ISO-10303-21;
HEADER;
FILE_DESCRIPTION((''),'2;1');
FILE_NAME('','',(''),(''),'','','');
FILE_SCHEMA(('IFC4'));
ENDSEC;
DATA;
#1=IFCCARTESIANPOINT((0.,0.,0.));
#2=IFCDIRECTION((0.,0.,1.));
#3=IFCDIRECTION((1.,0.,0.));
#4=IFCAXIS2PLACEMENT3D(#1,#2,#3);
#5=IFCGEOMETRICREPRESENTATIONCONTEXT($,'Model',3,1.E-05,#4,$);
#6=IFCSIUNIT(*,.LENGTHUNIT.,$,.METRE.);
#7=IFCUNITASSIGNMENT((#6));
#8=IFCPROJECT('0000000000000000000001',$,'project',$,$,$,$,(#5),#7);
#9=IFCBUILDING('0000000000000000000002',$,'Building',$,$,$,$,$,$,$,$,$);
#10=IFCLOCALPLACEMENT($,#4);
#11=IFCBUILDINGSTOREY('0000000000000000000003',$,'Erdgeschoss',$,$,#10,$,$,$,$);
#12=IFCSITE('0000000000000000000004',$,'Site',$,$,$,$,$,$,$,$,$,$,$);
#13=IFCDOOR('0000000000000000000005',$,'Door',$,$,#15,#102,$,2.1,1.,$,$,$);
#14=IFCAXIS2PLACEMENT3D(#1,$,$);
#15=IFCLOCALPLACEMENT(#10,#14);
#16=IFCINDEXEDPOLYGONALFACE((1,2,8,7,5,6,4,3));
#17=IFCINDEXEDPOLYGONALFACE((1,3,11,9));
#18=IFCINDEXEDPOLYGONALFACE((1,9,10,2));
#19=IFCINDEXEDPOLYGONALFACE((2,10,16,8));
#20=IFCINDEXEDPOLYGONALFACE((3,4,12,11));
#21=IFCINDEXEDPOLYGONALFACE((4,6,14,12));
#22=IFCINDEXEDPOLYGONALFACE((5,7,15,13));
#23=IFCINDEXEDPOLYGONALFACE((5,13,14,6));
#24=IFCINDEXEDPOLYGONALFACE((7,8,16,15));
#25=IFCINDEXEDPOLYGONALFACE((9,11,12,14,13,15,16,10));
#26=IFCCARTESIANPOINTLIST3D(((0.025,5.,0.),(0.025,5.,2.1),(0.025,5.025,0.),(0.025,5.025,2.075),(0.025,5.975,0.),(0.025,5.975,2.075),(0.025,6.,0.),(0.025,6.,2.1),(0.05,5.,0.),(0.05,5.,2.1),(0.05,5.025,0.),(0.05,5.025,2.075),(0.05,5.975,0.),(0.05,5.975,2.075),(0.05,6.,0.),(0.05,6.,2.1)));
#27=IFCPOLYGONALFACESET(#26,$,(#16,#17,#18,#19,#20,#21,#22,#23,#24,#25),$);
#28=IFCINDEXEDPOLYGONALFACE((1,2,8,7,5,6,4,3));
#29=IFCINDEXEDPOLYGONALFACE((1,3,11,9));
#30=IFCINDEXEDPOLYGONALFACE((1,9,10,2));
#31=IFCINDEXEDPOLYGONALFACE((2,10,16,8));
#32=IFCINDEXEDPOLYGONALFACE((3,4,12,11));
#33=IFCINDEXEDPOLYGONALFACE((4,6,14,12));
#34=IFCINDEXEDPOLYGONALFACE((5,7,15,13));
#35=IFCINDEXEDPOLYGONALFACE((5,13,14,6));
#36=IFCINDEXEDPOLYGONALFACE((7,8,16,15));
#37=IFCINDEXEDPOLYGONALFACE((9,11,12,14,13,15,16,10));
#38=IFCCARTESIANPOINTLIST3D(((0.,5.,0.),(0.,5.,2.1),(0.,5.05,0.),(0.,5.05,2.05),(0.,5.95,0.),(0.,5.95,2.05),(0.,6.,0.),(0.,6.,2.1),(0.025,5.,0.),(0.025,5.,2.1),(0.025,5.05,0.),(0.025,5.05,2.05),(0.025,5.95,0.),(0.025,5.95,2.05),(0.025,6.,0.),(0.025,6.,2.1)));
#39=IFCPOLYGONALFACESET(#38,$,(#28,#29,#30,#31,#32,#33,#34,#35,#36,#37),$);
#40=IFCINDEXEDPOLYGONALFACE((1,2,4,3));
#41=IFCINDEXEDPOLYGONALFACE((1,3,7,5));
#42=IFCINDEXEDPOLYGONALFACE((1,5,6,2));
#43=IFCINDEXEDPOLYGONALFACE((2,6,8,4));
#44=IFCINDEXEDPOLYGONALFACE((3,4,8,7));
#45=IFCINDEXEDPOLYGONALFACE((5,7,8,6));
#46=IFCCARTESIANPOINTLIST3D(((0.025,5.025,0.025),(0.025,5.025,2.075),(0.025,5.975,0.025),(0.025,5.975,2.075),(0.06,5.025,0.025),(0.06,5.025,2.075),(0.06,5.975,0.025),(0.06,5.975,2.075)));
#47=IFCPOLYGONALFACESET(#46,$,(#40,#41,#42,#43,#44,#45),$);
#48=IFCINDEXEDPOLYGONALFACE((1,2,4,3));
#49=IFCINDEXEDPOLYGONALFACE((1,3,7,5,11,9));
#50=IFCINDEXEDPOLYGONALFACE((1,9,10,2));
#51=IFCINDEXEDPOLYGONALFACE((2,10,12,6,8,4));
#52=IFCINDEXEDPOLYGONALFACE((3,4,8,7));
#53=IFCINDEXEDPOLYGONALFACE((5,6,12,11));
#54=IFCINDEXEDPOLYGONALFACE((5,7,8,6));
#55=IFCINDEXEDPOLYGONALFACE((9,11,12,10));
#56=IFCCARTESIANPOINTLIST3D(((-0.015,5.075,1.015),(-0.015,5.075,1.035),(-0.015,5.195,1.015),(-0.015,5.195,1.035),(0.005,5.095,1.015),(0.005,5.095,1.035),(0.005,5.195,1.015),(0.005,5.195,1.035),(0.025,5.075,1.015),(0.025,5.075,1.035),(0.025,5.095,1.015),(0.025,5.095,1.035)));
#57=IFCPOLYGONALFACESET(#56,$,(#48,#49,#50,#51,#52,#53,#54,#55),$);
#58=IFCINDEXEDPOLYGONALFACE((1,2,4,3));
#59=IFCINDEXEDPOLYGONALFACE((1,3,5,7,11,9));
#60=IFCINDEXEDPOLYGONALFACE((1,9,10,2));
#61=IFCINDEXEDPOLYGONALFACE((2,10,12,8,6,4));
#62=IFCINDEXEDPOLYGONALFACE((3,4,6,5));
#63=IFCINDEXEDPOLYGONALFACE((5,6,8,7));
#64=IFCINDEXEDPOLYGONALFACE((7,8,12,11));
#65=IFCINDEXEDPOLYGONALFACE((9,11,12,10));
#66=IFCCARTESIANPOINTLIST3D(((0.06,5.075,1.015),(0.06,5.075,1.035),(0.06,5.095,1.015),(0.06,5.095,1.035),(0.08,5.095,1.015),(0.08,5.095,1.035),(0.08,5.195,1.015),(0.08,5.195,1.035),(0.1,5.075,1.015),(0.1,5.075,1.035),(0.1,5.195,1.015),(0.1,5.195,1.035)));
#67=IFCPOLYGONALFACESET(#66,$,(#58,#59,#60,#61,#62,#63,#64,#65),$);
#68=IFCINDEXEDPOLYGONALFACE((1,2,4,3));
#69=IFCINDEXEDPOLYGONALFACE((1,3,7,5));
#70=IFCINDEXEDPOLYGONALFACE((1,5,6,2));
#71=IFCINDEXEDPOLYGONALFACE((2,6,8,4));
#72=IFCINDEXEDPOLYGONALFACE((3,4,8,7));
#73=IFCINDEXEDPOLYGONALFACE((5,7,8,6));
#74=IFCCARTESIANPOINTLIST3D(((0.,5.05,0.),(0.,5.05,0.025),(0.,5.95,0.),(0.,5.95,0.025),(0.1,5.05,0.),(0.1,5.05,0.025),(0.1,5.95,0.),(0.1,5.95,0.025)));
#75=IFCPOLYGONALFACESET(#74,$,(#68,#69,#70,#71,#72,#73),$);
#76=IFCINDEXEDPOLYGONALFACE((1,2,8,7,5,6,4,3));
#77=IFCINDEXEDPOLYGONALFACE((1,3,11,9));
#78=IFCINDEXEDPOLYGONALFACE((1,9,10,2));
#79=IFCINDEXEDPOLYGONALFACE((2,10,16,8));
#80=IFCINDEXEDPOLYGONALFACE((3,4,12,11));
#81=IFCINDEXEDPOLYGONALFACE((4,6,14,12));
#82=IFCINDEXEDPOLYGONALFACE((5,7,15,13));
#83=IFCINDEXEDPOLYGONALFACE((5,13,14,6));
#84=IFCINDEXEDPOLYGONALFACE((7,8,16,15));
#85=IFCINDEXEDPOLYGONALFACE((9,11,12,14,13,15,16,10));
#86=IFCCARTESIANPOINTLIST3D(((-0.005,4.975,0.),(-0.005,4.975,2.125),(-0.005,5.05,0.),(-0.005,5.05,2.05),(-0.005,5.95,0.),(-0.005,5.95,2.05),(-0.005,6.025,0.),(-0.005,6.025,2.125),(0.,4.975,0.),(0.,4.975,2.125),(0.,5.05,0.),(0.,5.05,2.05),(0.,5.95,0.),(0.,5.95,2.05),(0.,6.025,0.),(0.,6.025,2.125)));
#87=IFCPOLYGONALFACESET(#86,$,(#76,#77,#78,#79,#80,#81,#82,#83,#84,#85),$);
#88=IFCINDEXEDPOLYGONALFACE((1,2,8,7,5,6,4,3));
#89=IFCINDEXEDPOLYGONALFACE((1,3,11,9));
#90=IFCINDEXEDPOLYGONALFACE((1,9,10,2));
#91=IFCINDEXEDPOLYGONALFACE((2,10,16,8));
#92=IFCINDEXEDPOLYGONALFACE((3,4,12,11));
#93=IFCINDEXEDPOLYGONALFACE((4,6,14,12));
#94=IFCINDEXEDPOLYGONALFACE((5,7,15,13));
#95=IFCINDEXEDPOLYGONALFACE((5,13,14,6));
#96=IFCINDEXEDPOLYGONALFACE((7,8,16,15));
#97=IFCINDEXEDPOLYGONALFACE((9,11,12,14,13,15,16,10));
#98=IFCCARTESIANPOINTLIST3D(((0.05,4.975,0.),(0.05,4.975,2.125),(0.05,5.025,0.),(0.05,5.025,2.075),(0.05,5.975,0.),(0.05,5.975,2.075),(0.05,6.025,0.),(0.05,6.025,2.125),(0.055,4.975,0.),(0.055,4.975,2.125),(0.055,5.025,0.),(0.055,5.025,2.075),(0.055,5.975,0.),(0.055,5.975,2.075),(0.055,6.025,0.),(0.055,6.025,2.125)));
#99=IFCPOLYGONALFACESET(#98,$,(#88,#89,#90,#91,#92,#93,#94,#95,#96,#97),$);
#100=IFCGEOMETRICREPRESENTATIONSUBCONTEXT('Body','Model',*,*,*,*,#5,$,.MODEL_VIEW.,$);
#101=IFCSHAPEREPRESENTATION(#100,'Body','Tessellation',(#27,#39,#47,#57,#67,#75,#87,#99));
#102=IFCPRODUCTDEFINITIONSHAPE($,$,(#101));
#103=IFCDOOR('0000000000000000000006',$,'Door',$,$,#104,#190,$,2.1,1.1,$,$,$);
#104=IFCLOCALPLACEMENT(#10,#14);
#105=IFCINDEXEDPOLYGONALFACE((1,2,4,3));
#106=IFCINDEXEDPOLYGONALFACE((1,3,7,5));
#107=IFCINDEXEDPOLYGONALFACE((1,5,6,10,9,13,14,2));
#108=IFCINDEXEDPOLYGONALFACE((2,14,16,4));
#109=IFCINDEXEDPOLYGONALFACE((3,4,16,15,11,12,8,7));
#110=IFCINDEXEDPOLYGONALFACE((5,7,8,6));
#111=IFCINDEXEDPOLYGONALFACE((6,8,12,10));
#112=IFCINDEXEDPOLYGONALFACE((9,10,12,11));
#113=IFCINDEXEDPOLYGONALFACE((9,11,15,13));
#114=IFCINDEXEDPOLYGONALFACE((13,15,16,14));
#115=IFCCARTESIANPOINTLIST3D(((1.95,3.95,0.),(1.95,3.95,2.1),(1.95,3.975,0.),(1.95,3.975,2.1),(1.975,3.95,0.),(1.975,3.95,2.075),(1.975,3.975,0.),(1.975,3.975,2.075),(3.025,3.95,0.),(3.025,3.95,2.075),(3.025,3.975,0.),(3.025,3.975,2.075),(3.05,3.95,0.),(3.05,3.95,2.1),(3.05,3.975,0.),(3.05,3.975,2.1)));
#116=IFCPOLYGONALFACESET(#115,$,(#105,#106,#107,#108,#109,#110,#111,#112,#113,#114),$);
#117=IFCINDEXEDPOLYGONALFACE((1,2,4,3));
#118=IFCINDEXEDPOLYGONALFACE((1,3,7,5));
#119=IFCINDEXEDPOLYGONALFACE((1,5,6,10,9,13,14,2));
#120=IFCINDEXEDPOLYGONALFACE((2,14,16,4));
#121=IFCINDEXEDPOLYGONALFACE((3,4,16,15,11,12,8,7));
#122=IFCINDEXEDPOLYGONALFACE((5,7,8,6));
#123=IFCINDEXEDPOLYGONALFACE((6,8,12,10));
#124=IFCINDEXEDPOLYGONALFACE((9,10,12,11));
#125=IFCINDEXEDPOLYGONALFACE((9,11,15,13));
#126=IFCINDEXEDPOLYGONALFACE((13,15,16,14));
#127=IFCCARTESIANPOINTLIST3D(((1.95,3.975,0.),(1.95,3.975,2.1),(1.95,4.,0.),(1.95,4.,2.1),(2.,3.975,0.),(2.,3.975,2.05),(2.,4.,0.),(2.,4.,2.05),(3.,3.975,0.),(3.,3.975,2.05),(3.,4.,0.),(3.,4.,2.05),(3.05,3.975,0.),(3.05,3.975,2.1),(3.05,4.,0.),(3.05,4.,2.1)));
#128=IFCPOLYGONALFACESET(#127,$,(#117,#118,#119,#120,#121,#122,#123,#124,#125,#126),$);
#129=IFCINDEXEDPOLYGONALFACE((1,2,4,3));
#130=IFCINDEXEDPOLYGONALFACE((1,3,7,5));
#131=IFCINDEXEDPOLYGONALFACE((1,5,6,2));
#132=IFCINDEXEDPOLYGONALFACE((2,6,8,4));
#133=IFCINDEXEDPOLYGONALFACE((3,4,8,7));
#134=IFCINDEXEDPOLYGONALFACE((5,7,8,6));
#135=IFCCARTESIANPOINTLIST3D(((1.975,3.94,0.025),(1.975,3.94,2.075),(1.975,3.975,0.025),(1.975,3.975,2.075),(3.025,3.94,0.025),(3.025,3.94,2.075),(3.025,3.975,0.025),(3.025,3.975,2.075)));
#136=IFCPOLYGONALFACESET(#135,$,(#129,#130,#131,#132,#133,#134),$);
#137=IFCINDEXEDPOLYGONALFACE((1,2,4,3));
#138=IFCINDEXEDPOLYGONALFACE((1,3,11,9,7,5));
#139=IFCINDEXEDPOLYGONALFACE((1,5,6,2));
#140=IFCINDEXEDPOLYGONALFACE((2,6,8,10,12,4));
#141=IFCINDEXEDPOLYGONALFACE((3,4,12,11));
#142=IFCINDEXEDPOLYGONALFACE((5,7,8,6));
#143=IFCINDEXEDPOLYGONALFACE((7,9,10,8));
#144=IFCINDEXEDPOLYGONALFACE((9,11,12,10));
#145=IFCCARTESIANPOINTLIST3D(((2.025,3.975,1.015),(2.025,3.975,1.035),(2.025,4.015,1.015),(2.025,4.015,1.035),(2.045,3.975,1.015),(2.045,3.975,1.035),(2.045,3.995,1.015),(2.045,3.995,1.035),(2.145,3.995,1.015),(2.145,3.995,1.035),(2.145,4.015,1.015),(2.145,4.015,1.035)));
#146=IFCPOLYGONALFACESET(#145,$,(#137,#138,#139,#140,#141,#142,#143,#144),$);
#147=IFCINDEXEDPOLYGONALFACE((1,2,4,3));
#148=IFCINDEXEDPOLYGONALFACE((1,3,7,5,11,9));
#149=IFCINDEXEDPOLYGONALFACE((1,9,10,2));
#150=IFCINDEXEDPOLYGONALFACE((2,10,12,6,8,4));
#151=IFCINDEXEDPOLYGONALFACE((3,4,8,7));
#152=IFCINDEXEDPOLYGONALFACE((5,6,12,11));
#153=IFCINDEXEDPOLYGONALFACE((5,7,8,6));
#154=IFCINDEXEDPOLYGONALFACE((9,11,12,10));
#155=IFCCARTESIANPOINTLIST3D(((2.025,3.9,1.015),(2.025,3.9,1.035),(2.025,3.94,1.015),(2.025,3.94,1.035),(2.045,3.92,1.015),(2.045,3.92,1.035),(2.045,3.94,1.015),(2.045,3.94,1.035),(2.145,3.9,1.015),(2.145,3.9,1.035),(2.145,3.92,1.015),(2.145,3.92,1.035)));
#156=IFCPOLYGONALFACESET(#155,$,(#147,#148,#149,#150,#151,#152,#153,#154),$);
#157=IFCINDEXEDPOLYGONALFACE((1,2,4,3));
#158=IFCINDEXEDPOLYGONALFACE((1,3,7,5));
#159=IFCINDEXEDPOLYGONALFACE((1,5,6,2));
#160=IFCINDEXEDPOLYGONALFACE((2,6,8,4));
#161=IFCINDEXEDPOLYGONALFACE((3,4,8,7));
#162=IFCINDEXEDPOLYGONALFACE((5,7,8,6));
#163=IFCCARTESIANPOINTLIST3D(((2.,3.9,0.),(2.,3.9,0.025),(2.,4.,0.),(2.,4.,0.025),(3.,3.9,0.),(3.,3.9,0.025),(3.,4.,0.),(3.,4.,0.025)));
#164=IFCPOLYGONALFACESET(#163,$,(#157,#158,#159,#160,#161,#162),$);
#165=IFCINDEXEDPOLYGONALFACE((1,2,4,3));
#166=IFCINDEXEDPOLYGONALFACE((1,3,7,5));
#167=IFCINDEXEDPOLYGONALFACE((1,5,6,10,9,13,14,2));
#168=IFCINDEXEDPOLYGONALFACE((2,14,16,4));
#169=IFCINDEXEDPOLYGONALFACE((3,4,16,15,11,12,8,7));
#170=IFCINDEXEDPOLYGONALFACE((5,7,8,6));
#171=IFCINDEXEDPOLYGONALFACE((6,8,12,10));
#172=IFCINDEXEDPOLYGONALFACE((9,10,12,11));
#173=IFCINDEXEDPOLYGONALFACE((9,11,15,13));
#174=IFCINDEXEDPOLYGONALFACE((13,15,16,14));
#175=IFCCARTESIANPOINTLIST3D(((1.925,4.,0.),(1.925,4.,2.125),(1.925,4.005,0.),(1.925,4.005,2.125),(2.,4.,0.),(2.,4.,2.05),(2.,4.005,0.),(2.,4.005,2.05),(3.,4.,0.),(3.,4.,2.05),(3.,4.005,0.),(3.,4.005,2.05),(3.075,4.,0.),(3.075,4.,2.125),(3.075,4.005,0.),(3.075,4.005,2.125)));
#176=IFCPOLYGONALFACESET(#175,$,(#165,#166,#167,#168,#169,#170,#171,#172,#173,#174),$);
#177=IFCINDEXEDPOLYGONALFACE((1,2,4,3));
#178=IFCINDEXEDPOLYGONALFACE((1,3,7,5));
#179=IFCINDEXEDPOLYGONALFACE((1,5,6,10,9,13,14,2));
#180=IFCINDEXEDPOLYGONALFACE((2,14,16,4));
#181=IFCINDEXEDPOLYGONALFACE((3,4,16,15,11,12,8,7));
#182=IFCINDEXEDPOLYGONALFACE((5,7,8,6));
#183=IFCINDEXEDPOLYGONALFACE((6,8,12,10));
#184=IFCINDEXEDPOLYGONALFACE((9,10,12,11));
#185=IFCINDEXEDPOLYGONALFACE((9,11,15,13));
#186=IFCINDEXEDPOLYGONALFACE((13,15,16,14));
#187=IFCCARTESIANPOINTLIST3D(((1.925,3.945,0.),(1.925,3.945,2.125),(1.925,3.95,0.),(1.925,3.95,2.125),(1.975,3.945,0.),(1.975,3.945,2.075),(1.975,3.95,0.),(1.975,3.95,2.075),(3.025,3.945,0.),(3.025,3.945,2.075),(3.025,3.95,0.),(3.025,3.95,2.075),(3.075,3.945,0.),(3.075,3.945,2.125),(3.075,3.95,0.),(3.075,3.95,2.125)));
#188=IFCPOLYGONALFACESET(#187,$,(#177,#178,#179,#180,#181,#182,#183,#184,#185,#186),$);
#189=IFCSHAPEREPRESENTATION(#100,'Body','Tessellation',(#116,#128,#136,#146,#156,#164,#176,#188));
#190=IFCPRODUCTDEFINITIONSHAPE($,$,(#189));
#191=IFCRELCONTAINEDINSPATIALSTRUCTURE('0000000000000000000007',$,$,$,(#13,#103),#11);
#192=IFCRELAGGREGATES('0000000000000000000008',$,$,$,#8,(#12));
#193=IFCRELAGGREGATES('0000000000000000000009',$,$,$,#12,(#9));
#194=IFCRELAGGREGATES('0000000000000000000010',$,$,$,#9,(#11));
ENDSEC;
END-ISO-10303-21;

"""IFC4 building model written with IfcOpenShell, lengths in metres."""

from ifc_helpers import new_model, si_unit, frame, origin_with_axes, place, context, subcontext, project, spatial, line, indexed_curve, outline, extrude, element, save


model = new_model("IFC4")

# Units and contexts
model_context = context("Model", 3, precision=1e-05, world=origin_with_axes())
body_context = subcontext(model_context, "Body", "Model", "MODEL_VIEW")
ifc_project = project(units=[si_unit("LENGTHUNIT", "METRE")], contexts=[model_context])

# Site, building, storey
site = spatial("IfcSite", under=ifc_project, Name="Site")
building = spatial("IfcBuilding", under=site, Name="Building")
storey_placement = place(None, origin_with_axes())
storey = spatial("IfcBuildingStorey", under=building, at=storey_placement, Name="Erdgeschoss")

# Doors
door_1_placement = place(storey_placement, frame((0.0, 6.0, 0.0), z_axis=(0.0, 0.0, 1.0), x_axis=(0.0, -1.0, 0.0)))
element("IfcDoor", 1, at=door_1_placement, inside=storey, Name="Door", OverallHeight=2.1, OverallWidth=1.0, context=body_context, shape_type="SweptSolid", body=[
    extrude(outline(indexed_curve([(0.0, 0.0), (0.0, 2.1), (1.0, 2.1), (1.0, 0.0), (0.975, 0.0), (0.975, 2.075), (0.025, 2.075), (0.025, 0.0)], segments=[line(1, 2, 3, 4, 5, 6, 7, 8, 1)])), frame((0.0, 0.025, 0.0), z_axis=(0.0, -1.0, 0.0), x_axis=(1.0, 0.0, 0.0)), (0.0, 0.0, -1.0), 0.025),
    extrude(outline(indexed_curve([(0.0, 0.0), (0.0, 2.1), (1.0, 2.1), (1.0, 0.0), (0.95, 0.0), (0.95, 2.05), (0.05, 2.05), (0.05, 0.0)], segments=[line(1, 2, 3, 4, 5, 6, 7, 8, 1)])), frame((0.0, 0.0, 0.0), z_axis=(0.0, -1.0, 0.0), x_axis=(1.0, 0.0, 0.0)), (0.0, 0.0, -1.0), 0.025),
    extrude(outline(indexed_curve([(0.0, 0.0), (0.95, 0.0), (0.95, 0.035), (0.0, 0.035)], segments=[line(1, 2, 3, 4, 1)])), frame((0.025, 0.025, 0.025), z_axis=(0.0, 0.0, 1.0), x_axis=(1.0, 0.0, 0.0)), (0.0, 0.0, 1.0), 2.05),
    extrude(outline(indexed_curve([(0.0, 0.0), (0.0, -0.04), (-0.12, -0.04), (-0.12, -0.02), (-0.02, -0.02), (-0.02, 0.0)], segments=[line(1, 2, 3, 4, 5, 6, 1)])), frame((0.925, 0.025, 1.015), z_axis=(0.0, 0.0, 1.0), x_axis=(1.0, 0.0, 0.0)), (0.0, 0.0, 1.0), 0.02),
    extrude(outline(indexed_curve([(0.0, 0.0), (0.0, 0.04), (-0.12, 0.04), (-0.12, 0.02), (-0.02, 0.02), (-0.02, 0.0)], segments=[line(1, 2, 3, 4, 5, 6, 1)])), frame((0.925, 0.06, 1.015), z_axis=(0.0, 0.0, 1.0), x_axis=(1.0, 0.0, 0.0)), (0.0, 0.0, 1.0), 0.02),
    extrude(outline(indexed_curve([(0.0, 0.0), (0.9, 0.0), (0.9, 0.1), (0.0, 0.1)], segments=[line(1, 2, 3, 4, 1)])), frame((0.05, 0.0, 0.0), z_axis=(0.0, 0.0, 1.0), x_axis=(1.0, 0.0, 0.0)), (0.0, 0.0, 1.0), 0.025),
    extrude(outline(indexed_curve([(0.0, 0.0), (0.0, 2.125), (1.05, 2.125), (1.05, 0.0), (0.975, 0.0), (0.975, 2.05), (0.075, 2.05), (0.075, 0.0)], segments=[line(1, 2, 3, 4, 5, 6, 7, 8, 1)])), frame((-0.025, -0.005, 0.0), z_axis=(0.0, -1.0, 0.0), x_axis=(1.0, 0.0, 0.0)), (0.0, 0.0, -1.0), 0.005),
    extrude(outline(indexed_curve([(0.0, 0.0), (0.0, 2.125), (1.05, 2.125), (1.05, 0.0), (1.0, 0.0), (1.0, 2.075), (0.05, 2.075), (0.05, 0.0)], segments=[line(1, 2, 3, 4, 5, 6, 7, 8, 1)])), frame((-0.025, 0.05, 0.0), z_axis=(0.0, -1.0, 0.0), x_axis=(1.0, 0.0, 0.0)), (0.0, 0.0, -1.0), 0.005),
])
door_2_placement = place(storey_placement, frame((3.05, 4.0, 0.0), z_axis=(0.0, 0.0, 1.0), x_axis=(-1.0, 0.0, 0.0)))
element("IfcDoor", 2, at=door_2_placement, inside=storey, Name="Door", OverallHeight=2.1, OverallWidth=1.1, context=body_context, shape_type="SweptSolid", body=[
    extrude(outline(indexed_curve([(0.0, 0.0), (0.0, 2.1), (1.1, 2.1), (1.1, 0.0), (1.075, 0.0), (1.075, 2.075), (0.025, 2.075), (0.025, 0.0)], segments=[line(1, 2, 3, 4, 5, 6, 7, 8, 1)])), frame((0.0, 0.025, 0.0), z_axis=(0.0, -1.0, 0.0), x_axis=(1.0, 0.0, 0.0)), (0.0, 0.0, -1.0), 0.025),
    extrude(outline(indexed_curve([(0.0, 0.0), (0.0, 2.1), (1.1, 2.1), (1.1, 0.0), (1.05, 0.0), (1.05, 2.05), (0.05, 2.05), (0.05, 0.0)], segments=[line(1, 2, 3, 4, 5, 6, 7, 8, 1)])), frame((0.0, 0.0, 0.0), z_axis=(0.0, -1.0, 0.0), x_axis=(1.0, 0.0, 0.0)), (0.0, 0.0, -1.0), 0.025),
    extrude(outline(indexed_curve([(0.0, 0.0), (1.05, 0.0), (1.05, 0.035), (0.0, 0.035)], segments=[line(1, 2, 3, 4, 1)])), frame((0.025, 0.025, 0.025), z_axis=(0.0, 0.0, 1.0), x_axis=(1.0, 0.0, 0.0)), (0.0, 0.0, 1.0), 2.05),
    extrude(outline(indexed_curve([(0.0, 0.0), (0.0, -0.04), (-0.12, -0.04), (-0.12, -0.02), (-0.02, -0.02), (-0.02, 0.0)], segments=[line(1, 2, 3, 4, 5, 6, 1)])), frame((1.025, 0.025, 1.015), z_axis=(0.0, 0.0, 1.0), x_axis=(1.0, 0.0, 0.0)), (0.0, 0.0, 1.0), 0.02),
    extrude(outline(indexed_curve([(0.0, 0.0), (0.0, 0.04), (-0.12, 0.04), (-0.12, 0.02), (-0.02, 0.02), (-0.02, 0.0)], segments=[line(1, 2, 3, 4, 5, 6, 1)])), frame((1.025, 0.06, 1.015), z_axis=(0.0, 0.0, 1.0), x_axis=(1.0, 0.0, 0.0)), (0.0, 0.0, 1.0), 0.02),
    extrude(outline(indexed_curve([(0.0, 0.0), (1.0, 0.0), (1.0, 0.1), (0.0, 0.1)], segments=[line(1, 2, 3, 4, 1)])), frame((0.05, 0.0, 0.0), z_axis=(0.0, 0.0, 1.0), x_axis=(1.0, 0.0, 0.0)), (0.0, 0.0, 1.0), 0.025),
    extrude(outline(indexed_curve([(0.0, 0.0), (0.0, 2.125), (1.15, 2.125), (1.15, 0.0), (1.075, 0.0), (1.075, 2.05), (0.075, 2.05), (0.075, 0.0)], segments=[line(1, 2, 3, 4, 5, 6, 7, 8, 1)])), frame((-0.025, -0.005, 0.0), z_axis=(0.0, -1.0, 0.0), x_axis=(1.0, 0.0, 0.0)), (0.0, 0.0, -1.0), 0.005),
    extrude(outline(indexed_curve([(0.0, 0.0), (0.0, 2.125), (1.15, 2.125), (1.15, 0.0), (1.1, 0.0), (1.1, 2.075), (0.05, 2.075), (0.05, 0.0)], segments=[line(1, 2, 3, 4, 5, 6, 7, 8, 1)])), frame((-0.025, 0.05, 0.0), z_axis=(0.0, -1.0, 0.0), x_axis=(1.0, 0.0, 0.0)), (0.0, 0.0, -1.0), 0.005),
])

save(model, "model.ifc")
